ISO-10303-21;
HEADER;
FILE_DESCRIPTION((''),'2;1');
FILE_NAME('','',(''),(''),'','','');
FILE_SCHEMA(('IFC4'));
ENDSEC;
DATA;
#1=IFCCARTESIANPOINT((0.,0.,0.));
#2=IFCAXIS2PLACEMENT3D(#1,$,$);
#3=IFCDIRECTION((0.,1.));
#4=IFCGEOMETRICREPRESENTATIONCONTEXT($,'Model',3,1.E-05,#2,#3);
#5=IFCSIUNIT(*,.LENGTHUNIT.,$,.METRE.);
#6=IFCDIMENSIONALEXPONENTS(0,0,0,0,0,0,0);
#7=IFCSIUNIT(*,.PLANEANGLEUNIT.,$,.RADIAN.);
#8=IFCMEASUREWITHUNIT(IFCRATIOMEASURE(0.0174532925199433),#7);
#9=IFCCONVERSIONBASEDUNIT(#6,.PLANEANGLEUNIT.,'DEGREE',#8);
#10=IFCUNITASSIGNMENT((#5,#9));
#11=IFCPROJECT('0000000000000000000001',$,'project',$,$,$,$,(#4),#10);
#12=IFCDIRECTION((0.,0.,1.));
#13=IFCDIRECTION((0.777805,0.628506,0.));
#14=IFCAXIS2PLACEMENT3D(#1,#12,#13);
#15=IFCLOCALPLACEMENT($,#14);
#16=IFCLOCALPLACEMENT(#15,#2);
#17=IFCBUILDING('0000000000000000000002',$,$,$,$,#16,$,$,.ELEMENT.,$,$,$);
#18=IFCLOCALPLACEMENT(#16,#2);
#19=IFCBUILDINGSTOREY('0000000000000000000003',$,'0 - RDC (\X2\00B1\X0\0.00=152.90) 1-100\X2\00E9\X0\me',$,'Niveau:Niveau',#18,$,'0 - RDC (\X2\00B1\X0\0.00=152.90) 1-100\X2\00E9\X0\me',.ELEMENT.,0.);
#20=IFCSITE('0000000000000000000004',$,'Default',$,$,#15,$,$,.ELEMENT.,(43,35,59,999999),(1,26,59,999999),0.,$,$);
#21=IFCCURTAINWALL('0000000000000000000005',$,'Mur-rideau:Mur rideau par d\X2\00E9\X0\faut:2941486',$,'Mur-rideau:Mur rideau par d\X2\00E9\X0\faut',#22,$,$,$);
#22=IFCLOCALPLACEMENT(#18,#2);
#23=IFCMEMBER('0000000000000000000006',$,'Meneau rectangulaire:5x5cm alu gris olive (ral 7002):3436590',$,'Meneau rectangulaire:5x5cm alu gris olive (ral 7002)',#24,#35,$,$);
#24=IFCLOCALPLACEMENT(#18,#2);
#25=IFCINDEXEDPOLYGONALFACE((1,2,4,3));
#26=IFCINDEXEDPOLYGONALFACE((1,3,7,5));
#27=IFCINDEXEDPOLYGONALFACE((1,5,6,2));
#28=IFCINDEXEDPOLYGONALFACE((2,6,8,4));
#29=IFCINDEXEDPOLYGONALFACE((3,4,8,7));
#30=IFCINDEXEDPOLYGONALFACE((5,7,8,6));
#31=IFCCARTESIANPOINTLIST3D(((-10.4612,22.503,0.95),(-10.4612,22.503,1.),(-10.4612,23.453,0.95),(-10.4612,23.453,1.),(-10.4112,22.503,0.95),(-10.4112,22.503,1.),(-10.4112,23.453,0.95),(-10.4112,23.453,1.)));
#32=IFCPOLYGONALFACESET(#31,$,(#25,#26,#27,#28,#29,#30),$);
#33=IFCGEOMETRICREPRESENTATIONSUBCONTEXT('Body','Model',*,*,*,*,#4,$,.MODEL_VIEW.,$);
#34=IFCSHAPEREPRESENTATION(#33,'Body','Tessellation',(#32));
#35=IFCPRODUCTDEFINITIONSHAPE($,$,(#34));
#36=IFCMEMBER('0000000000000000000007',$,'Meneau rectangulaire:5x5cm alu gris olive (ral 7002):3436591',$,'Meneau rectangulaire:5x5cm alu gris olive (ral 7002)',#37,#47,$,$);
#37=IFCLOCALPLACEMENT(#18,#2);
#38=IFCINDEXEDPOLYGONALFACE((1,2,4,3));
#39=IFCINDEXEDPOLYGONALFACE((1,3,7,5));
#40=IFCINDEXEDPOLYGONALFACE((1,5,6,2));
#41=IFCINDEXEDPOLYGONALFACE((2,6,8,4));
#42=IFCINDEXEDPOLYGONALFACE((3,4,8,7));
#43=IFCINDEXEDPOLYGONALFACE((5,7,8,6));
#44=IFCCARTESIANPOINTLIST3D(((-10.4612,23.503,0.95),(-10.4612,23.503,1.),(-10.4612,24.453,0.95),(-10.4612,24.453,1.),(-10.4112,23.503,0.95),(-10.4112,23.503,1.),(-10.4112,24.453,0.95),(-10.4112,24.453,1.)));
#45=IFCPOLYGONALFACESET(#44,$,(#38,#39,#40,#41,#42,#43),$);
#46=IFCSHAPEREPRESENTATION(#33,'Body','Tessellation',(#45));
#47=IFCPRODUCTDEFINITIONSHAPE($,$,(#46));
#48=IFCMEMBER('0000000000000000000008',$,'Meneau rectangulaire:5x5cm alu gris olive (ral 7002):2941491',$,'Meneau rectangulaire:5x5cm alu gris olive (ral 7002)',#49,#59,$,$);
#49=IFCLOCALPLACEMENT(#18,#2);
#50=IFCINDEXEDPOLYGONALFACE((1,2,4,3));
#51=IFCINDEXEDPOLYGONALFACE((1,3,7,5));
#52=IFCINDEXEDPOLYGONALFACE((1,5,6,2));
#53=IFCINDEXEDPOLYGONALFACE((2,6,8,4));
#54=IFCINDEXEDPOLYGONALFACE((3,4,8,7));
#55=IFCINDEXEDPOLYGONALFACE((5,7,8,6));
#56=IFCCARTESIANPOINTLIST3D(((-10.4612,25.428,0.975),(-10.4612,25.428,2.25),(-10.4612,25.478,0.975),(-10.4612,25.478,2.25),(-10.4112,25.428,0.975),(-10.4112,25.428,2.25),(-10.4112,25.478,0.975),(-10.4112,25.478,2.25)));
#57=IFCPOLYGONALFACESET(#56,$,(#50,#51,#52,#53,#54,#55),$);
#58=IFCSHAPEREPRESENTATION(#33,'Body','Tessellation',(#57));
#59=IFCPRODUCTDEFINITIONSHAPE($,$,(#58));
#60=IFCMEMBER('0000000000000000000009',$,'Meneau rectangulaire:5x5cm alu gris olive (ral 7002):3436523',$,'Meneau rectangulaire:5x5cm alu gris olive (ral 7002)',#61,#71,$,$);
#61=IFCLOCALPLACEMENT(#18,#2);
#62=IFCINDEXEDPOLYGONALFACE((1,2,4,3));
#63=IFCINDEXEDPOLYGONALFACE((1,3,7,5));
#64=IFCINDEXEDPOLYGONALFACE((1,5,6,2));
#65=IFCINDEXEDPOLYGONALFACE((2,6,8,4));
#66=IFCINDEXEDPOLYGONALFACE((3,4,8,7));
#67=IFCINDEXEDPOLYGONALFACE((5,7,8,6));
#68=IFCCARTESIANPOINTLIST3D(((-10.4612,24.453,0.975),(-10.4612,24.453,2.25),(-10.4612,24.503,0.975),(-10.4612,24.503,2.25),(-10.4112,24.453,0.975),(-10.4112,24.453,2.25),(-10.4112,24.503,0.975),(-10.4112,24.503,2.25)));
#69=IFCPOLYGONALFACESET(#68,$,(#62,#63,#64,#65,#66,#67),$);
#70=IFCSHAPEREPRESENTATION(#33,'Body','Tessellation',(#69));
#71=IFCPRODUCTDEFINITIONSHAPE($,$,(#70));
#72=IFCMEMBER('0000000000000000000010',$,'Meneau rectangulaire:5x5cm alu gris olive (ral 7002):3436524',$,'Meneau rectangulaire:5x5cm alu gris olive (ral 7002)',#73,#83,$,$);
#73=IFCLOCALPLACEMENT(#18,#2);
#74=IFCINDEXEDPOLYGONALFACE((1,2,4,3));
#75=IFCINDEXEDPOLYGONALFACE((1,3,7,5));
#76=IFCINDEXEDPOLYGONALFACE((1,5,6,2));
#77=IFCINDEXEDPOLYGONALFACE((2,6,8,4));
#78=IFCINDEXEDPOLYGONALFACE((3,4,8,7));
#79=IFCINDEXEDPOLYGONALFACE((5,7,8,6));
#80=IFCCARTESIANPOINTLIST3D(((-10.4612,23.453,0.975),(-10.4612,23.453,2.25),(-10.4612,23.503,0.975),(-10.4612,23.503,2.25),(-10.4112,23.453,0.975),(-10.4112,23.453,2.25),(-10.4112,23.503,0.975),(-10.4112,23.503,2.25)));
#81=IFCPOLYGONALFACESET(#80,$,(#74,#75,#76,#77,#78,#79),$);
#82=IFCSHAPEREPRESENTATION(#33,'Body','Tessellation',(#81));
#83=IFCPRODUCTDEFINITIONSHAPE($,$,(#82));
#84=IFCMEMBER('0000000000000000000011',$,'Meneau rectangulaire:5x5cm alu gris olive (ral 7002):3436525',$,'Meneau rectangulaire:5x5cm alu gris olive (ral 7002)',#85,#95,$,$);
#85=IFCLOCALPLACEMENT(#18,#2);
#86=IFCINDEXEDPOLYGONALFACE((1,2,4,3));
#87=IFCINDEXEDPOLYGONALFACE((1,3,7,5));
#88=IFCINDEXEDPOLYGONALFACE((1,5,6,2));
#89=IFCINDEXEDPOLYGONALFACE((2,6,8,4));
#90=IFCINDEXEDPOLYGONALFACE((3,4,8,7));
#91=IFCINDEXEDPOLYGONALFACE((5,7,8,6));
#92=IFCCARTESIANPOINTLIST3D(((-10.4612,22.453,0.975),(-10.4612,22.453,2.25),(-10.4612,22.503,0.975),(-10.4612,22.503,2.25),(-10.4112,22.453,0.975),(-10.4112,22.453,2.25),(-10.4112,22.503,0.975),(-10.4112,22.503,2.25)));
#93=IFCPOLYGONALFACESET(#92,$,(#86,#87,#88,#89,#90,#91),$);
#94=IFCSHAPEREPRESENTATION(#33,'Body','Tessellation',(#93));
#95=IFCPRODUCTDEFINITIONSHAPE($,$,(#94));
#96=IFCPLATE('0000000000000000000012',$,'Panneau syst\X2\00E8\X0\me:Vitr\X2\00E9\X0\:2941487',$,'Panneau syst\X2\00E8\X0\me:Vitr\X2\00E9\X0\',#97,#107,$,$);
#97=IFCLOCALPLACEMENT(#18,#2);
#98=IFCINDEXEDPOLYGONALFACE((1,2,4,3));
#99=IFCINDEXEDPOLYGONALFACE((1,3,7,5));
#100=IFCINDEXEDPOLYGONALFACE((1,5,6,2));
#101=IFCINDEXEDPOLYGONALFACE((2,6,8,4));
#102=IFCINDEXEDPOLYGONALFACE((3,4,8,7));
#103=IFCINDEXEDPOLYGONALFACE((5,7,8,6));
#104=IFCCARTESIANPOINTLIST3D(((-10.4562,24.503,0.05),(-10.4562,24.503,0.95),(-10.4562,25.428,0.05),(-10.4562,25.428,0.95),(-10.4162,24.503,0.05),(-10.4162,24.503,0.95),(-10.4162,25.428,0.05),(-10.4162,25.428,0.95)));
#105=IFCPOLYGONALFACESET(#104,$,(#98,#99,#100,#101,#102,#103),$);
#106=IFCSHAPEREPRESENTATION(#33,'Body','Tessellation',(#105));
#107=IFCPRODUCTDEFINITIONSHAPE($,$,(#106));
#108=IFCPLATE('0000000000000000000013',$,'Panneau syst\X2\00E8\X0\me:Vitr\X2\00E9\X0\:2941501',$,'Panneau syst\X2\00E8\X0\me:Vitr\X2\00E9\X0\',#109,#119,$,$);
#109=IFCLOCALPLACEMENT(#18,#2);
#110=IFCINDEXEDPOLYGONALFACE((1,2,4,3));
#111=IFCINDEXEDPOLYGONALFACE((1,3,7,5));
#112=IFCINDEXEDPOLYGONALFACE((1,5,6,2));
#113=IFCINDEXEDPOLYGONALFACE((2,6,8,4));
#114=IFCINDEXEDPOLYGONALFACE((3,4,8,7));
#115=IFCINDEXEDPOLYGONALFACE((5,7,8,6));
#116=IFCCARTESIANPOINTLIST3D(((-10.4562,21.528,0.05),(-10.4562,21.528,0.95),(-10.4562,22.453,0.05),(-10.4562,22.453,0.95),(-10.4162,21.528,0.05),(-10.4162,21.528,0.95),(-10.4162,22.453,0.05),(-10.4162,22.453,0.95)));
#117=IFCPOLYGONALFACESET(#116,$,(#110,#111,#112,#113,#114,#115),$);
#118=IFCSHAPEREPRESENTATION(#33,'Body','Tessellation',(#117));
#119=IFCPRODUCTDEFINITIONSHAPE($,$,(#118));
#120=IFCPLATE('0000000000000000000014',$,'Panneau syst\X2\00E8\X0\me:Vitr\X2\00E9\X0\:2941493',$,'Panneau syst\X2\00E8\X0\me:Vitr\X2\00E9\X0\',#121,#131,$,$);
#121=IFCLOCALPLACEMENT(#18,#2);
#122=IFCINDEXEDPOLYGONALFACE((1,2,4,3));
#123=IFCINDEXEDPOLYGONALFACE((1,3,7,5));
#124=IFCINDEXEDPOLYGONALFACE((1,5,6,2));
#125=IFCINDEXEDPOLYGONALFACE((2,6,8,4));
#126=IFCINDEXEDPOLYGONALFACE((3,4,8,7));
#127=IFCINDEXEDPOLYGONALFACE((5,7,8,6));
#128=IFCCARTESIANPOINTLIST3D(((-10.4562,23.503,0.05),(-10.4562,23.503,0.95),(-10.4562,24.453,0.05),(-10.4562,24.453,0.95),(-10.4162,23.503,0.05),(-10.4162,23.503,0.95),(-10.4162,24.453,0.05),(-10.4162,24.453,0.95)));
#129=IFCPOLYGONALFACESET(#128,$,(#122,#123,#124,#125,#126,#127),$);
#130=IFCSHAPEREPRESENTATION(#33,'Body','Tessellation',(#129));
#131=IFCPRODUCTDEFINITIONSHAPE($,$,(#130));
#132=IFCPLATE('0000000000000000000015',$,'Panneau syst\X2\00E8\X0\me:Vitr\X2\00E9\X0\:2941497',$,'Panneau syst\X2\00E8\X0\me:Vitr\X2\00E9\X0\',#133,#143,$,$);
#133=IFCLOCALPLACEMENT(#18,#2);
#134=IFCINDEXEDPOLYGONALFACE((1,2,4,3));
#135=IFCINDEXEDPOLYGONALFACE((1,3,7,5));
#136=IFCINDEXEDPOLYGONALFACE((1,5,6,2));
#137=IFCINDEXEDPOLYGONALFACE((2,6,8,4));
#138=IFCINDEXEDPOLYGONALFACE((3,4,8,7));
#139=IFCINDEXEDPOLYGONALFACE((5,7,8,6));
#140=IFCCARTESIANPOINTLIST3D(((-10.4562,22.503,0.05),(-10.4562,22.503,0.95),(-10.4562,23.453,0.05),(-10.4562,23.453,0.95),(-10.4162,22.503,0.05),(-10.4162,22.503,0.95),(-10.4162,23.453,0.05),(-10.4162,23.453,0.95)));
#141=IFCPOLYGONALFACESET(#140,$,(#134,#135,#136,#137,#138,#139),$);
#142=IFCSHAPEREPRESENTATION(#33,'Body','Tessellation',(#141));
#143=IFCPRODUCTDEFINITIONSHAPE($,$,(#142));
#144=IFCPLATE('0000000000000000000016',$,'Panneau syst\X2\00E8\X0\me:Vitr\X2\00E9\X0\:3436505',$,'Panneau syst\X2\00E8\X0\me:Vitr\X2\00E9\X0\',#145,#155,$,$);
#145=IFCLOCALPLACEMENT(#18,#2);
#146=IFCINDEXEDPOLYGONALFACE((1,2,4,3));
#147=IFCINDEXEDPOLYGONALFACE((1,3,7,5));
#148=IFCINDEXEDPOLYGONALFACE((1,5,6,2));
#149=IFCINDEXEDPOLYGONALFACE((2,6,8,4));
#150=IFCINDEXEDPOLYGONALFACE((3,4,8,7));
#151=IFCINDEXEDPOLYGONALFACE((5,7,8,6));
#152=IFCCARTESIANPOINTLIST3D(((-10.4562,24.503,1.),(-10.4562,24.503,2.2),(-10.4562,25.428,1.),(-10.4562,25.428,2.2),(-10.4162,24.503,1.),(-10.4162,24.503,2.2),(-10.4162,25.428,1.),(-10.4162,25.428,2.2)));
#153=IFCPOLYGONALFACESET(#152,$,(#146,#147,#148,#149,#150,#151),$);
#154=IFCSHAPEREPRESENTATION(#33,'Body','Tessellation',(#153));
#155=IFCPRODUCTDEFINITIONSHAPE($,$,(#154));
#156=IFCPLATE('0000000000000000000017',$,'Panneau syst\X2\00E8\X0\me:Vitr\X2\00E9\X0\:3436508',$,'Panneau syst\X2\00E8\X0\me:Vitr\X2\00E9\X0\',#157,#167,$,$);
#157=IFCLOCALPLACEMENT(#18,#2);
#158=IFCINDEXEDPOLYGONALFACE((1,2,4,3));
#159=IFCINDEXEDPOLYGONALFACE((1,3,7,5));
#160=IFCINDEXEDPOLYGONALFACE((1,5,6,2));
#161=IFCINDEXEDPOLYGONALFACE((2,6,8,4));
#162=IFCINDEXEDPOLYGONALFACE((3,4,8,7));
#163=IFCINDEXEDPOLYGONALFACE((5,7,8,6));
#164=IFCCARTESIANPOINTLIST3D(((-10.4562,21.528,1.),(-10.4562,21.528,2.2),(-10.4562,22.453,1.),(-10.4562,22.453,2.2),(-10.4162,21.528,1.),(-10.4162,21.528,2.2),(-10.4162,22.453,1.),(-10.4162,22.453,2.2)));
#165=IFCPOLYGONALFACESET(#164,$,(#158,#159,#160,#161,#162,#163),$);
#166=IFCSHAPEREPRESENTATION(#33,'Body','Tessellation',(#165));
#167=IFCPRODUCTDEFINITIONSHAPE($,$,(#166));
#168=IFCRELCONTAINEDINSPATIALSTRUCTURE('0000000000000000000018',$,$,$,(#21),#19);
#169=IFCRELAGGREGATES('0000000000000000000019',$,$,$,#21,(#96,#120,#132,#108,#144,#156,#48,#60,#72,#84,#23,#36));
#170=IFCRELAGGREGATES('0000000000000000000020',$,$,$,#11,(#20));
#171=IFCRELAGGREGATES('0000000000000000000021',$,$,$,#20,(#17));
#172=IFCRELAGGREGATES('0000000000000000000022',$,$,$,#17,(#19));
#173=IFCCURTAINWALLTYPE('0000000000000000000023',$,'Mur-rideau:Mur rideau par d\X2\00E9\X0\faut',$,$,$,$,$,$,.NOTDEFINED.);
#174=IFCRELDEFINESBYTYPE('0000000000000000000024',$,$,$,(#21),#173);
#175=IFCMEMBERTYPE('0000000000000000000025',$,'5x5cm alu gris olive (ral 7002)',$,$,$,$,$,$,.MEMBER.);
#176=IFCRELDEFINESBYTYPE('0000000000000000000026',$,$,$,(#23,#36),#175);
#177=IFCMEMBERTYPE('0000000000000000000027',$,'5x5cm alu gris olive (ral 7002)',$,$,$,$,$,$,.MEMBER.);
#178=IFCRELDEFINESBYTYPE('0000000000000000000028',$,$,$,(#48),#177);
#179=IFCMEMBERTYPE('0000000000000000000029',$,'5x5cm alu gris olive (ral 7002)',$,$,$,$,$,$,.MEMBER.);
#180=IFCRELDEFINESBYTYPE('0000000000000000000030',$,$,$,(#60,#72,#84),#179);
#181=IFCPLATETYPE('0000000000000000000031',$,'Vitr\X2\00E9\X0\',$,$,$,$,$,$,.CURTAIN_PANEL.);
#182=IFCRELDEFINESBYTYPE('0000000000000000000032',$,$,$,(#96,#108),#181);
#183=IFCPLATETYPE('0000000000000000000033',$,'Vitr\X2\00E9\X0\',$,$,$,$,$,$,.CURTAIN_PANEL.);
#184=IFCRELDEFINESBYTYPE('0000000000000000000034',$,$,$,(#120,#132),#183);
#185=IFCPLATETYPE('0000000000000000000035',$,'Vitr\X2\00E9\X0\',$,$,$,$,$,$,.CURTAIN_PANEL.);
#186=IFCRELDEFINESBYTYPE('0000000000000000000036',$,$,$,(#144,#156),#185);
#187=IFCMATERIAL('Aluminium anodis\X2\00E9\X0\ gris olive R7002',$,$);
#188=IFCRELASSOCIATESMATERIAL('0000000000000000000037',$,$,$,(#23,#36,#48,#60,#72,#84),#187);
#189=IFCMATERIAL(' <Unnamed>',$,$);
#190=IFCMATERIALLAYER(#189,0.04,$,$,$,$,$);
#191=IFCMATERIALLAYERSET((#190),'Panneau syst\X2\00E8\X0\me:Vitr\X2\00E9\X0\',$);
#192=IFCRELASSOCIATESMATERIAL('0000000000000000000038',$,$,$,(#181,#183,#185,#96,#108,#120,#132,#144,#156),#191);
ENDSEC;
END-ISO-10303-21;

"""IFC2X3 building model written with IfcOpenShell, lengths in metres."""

from ifc_helpers import new_model, entity, si_unit, converted_unit, direction, frame, frame_2d, origin, origin_2d_with_axis, place, context, subcontext, project, spatial, rectangle, extrude, source, transform, mapped, material, layer, layer_set, layer_usage, type_object, type_shapes, element, aggregate, save


model = new_model("IFC2X3")

# Units and contexts
model_context = context("Model", 3, precision=1e-05, world=origin(), true_north=direction((0.0, 1.0)))
body_context = subcontext(model_context, "Body", "Model", "MODEL_VIEW")
ifc_project = project(units=[si_unit("LENGTHUNIT", "METRE"), converted_unit("PLANEANGLEUNIT", "DEGREE", entity("IfcRatioMeasure", 0.0174532925199433), si_unit("PLANEANGLEUNIT", "RADIAN"), dimensions=[0, 0, 0, 0, 0, 0, 0])], contexts=[model_context])

# Site, building, storey
site_placement = place(None, frame((0.0, 0.0, 0.0), z_axis=(0.0, 0.0, 1.0), x_axis=(0.777805, 0.628506, 0.0)))
site = spatial("IfcSite", under=ifc_project, at=site_placement, Name="Default", CompositionType="ELEMENT", RefLatitude=(43, 35, 59, 999999), RefLongitude=(1, 26, 59, 999999), RefElevation=0.0)
building_placement = place(site_placement, origin())
building = spatial("IfcBuilding", under=site, at=building_placement, CompositionType="ELEMENT")
storey_placement = place(building_placement, origin())
storey = spatial("IfcBuildingStorey", under=building, at=storey_placement, Name="0 - RDC (±0.00=152.90) 1-100éme", ObjectType="Niveau:Niveau", LongName="0 - RDC (±0.00=152.90) 1-100éme", CompositionType="ELEMENT", Elevation=0.0)

# Curtain wall, members, plates
curtain_wall_type = type_object("IfcCurtainWallType", Name="Mur-rideau:Mur rideau par défaut", PredefinedType="NOTDEFINED")
curtain_wall_placement = place(storey_placement, origin())
curtain_wall = element("IfcCurtainWall", 1, at=curtain_wall_placement, inside=storey, type_object=curtain_wall_type, Name="Mur-rideau:Mur rideau par défaut:2941486", ObjectType="Mur-rideau:Mur rideau par défaut")
ifc_material_1 = material(Name="Aluminium anodisé gris olive R7002")
member_type_1 = type_object("IfcMemberType", Name="5x5cm alu gris olive (ral 7002)", PredefinedType="MEMBER")
shared_shape_1 = source(origin(), body_context, "Body", "SweptSolid", [
    extrude(rectangle(XDim=0.05, YDim=0.05, at=origin_2d_with_axis()), frame((0.0, 0.0, -0.95), z_axis=(0.0, 0.0, 1.0), x_axis=(0.0, -1.0, 0.0)), (0.0, 0.0, 1.0), 0.95),
])
type_shapes(member_type_1, [shared_shape_1])
member_1_placement = place(storey_placement, frame((-10.4362, 22.503, 0.975), z_axis=(0.0, -1.0, 0.0), x_axis=(0.0, 0.0, 1.0)))
member_1 = element("IfcMember", 2, at=member_1_placement, type_object=member_type_1, material=ifc_material_1, Name="Meneau rectangulaire:5x5cm alu gris olive (ral 7002):3436590", ObjectType="Meneau rectangulaire:5x5cm alu gris olive (ral 7002)", context=body_context, shape_type="MappedRepresentation", body=[
    mapped(shared_shape_1, transform((0.0, 0.0, 0.0), scale=1.0)),
])
member_2_placement = place(storey_placement, frame((-10.4362, 23.503, 0.975), z_axis=(0.0, -1.0, 0.0), x_axis=(0.0, 0.0, 1.0)))
member_2 = element("IfcMember", 3, at=member_2_placement, type_object=member_type_1, material=ifc_material_1, Name="Meneau rectangulaire:5x5cm alu gris olive (ral 7002):3436591", ObjectType="Meneau rectangulaire:5x5cm alu gris olive (ral 7002)", context=body_context, shape_type="MappedRepresentation", body=[
    mapped(shared_shape_1, transform((0.0, 0.0, 0.0), scale=1.0)),
])
member_type_2 = type_object("IfcMemberType", Name="5x5cm alu gris olive (ral 7002)", PredefinedType="MEMBER")
shared_shape_2 = source(origin(), body_context, "Body", "SweptSolid", [
    extrude(rectangle(XDim=0.05, YDim=0.05, at=origin_2d_with_axis()), frame((-0.025, 0.0, -1.275), z_axis=(0.0, 0.0, 1.0), x_axis=(0.0, -1.0, 0.0)), (0.0, 0.0, 1.0), 1.275),
])
type_shapes(member_type_2, [shared_shape_2])
member_3_placement = place(storey_placement, frame((-10.4362, 25.478, 2.25), z_axis=(0.0, 0.0, 1.0), x_axis=(0.0, 1.0, 0.0)))
member_3 = element("IfcMember", 4, at=member_3_placement, type_object=member_type_2, material=ifc_material_1, Name="Meneau rectangulaire:5x5cm alu gris olive (ral 7002):2941491", ObjectType="Meneau rectangulaire:5x5cm alu gris olive (ral 7002)", context=body_context, shape_type="MappedRepresentation", body=[
    mapped(shared_shape_2, transform((0.0, 0.0, 0.0), scale=1.0)),
])
member_type_3 = type_object("IfcMemberType", Name="5x5cm alu gris olive (ral 7002)", PredefinedType="MEMBER")
shared_shape_3 = source(origin(), body_context, "Body", "SweptSolid", [
    extrude(rectangle(XDim=0.05, YDim=0.05, at=origin_2d_with_axis()), frame((0.0, 0.0, -1.275), z_axis=(0.0, 0.0, 1.0), x_axis=(0.0, -1.0, 0.0)), (0.0, 0.0, 1.0), 1.275),
])
type_shapes(member_type_3, [shared_shape_3])
member_4_placement = place(storey_placement, frame((-10.4362, 24.478, 0.975), z_axis=(0.0, 0.0, -1.0), x_axis=(0.0, -1.0, 0.0)))
member_4 = element("IfcMember", 5, at=member_4_placement, type_object=member_type_3, material=ifc_material_1, Name="Meneau rectangulaire:5x5cm alu gris olive (ral 7002):3436523", ObjectType="Meneau rectangulaire:5x5cm alu gris olive (ral 7002)", context=body_context, shape_type="MappedRepresentation", body=[
    mapped(shared_shape_3, transform((0.0, 0.0, 0.0), scale=1.0)),
])
member_5_placement = place(storey_placement, frame((-10.4362, 23.478, 0.975), z_axis=(0.0, 0.0, -1.0), x_axis=(0.0, -1.0, 0.0)))
member_5 = element("IfcMember", 6, at=member_5_placement, type_object=member_type_3, material=ifc_material_1, Name="Meneau rectangulaire:5x5cm alu gris olive (ral 7002):3436524", ObjectType="Meneau rectangulaire:5x5cm alu gris olive (ral 7002)", context=body_context, shape_type="MappedRepresentation", body=[
    mapped(shared_shape_3, transform((0.0, 0.0, 0.0), scale=1.0)),
])
member_6_placement = place(storey_placement, frame((-10.4362, 22.478, 0.975), z_axis=(0.0, 0.0, -1.0), x_axis=(0.0, -1.0, 0.0)))
member_6 = element("IfcMember", 7, at=member_6_placement, type_object=member_type_3, material=ifc_material_1, Name="Meneau rectangulaire:5x5cm alu gris olive (ral 7002):3436525", ObjectType="Meneau rectangulaire:5x5cm alu gris olive (ral 7002)", context=body_context, shape_type="MappedRepresentation", body=[
    mapped(shared_shape_3, transform((0.0, 0.0, 0.0), scale=1.0)),
])
ifc_material_2 = material(Name=" <Unnamed>")
ifc_layer_1 = layer(ifc_material_2, 0.04)
ifc_layer_set_1 = layer_set([ifc_layer_1], Name="Panneau système:Vitré")
ifc_layer_usage_1 = layer_usage(ifc_layer_set_1, "AXIS3", "POSITIVE", 0.0)
plate_type_1 = type_object("IfcPlateType", Name="Vitré", PredefinedType="CURTAIN_PANEL", material=ifc_layer_set_1)
shared_shape_4 = source(origin(), body_context, "Body", "SweptSolid", [
    extrude(rectangle(XDim=0.04, YDim=0.925, at=frame_2d((0.0, 0.0), x_axis=(1.0, 0.0))), frame((0.0, 0.0, 0.0), z_axis=(0.0, 0.0, 1.0), x_axis=(0.0, 1.0, 0.0)), (0.0, 0.0, 1.0), 0.9),
])
type_shapes(plate_type_1, [shared_shape_4])
plate_1_placement = place(curtain_wall_placement, frame((-10.4362, 24.9655, 0.05), z_axis=(0.0, 0.0, 1.0), x_axis=(0.0, -1.0, 0.0)))
plate_1 = element("IfcPlate", 8, at=plate_1_placement, type_object=plate_type_1, material=ifc_layer_usage_1, Name="Panneau système:Vitré:2941487", ObjectType="Panneau système:Vitré", context=body_context, shape_type="MappedRepresentation", body=[
    mapped(shared_shape_4, transform((0.0, 0.0, 0.0), scale=1.0)),
])
ifc_layer_usage_2 = layer_usage(ifc_layer_set_1, "AXIS3", "POSITIVE", 0.0)
plate_2_placement = place(curtain_wall_placement, frame((-10.4362, 21.9905, 0.05), z_axis=(0.0, 0.0, 1.0), x_axis=(0.0, -1.0, 0.0)))
plate_2 = element("IfcPlate", 9, at=plate_2_placement, type_object=plate_type_1, material=ifc_layer_usage_2, Name="Panneau système:Vitré:2941501", ObjectType="Panneau système:Vitré", context=body_context, shape_type="MappedRepresentation", body=[
    mapped(shared_shape_4, transform((0.0, 0.0, 0.0), scale=1.0)),
])
ifc_layer_usage_3 = layer_usage(ifc_layer_set_1, "AXIS3", "POSITIVE", 0.0)
plate_type_2 = type_object("IfcPlateType", Name="Vitré", PredefinedType="CURTAIN_PANEL", material=ifc_layer_set_1)
shared_shape_5 = source(origin(), body_context, "Body", "SweptSolid", [
    extrude(rectangle(XDim=0.04, YDim=0.95, at=frame_2d((0.0, 0.0), x_axis=(1.0, 0.0))), frame((0.0, 0.0, 0.0), z_axis=(0.0, 0.0, 1.0), x_axis=(0.0, 1.0, 0.0)), (0.0, 0.0, 1.0), 0.9),
])
type_shapes(plate_type_2, [shared_shape_5])
plate_3_placement = place(curtain_wall_placement, frame((-10.4362, 23.978, 0.05), z_axis=(0.0, 0.0, 1.0), x_axis=(0.0, -1.0, 0.0)))
plate_3 = element("IfcPlate", 10, at=plate_3_placement, type_object=plate_type_2, material=ifc_layer_usage_3, Name="Panneau système:Vitré:2941493", ObjectType="Panneau système:Vitré", context=body_context, shape_type="MappedRepresentation", body=[
    mapped(shared_shape_5, transform((0.0, 0.0, 0.0), scale=1.0)),
])
ifc_layer_usage_4 = layer_usage(ifc_layer_set_1, "AXIS3", "POSITIVE", 0.0)
plate_4_placement = place(curtain_wall_placement, frame((-10.4362, 22.978, 0.05), z_axis=(0.0, 0.0, 1.0), x_axis=(0.0, -1.0, 0.0)))
plate_4 = element("IfcPlate", 11, at=plate_4_placement, type_object=plate_type_2, material=ifc_layer_usage_4, Name="Panneau système:Vitré:2941497", ObjectType="Panneau système:Vitré", context=body_context, shape_type="MappedRepresentation", body=[
    mapped(shared_shape_5, transform((0.0, 0.0, 0.0), scale=1.0)),
])
ifc_layer_usage_5 = layer_usage(ifc_layer_set_1, "AXIS3", "POSITIVE", 0.0)
plate_type_3 = type_object("IfcPlateType", Name="Vitré", PredefinedType="CURTAIN_PANEL", material=ifc_layer_set_1)
shared_shape_6 = source(origin(), body_context, "Body", "SweptSolid", [
    extrude(rectangle(XDim=0.04, YDim=0.925, at=frame_2d((0.0, 0.0), x_axis=(1.0, 0.0))), frame((0.0, 0.0, 0.0), z_axis=(0.0, 0.0, 1.0), x_axis=(0.0, 1.0, 0.0)), (0.0, 0.0, 1.0), 1.2),
])
type_shapes(plate_type_3, [shared_shape_6])
plate_5_placement = place(curtain_wall_placement, frame((-10.4362, 24.9655, 1.0), z_axis=(0.0, 0.0, 1.0), x_axis=(0.0, -1.0, 0.0)))
plate_5 = element("IfcPlate", 12, at=plate_5_placement, type_object=plate_type_3, material=ifc_layer_usage_5, Name="Panneau système:Vitré:3436505", ObjectType="Panneau système:Vitré", context=body_context, shape_type="MappedRepresentation", body=[
    mapped(shared_shape_6, transform((0.0, 0.0, 0.0), scale=1.0)),
])
ifc_layer_usage_6 = layer_usage(ifc_layer_set_1, "AXIS3", "POSITIVE", 0.0)
plate_6_placement = place(curtain_wall_placement, frame((-10.4362, 21.9905, 1.0), z_axis=(0.0, 0.0, 1.0), x_axis=(0.0, -1.0, 0.0)))
plate_6 = element("IfcPlate", 13, at=plate_6_placement, type_object=plate_type_3, material=ifc_layer_usage_6, Name="Panneau système:Vitré:3436508", ObjectType="Panneau système:Vitré", context=body_context, shape_type="MappedRepresentation", body=[
    mapped(shared_shape_6, transform((0.0, 0.0, 0.0), scale=1.0)),
])
aggregate(curtain_wall, [plate_1, plate_3, plate_4, plate_2, plate_5, plate_6, member_3, member_4, member_5, member_6, member_1, member_2])

save(model, "model.ifc")
